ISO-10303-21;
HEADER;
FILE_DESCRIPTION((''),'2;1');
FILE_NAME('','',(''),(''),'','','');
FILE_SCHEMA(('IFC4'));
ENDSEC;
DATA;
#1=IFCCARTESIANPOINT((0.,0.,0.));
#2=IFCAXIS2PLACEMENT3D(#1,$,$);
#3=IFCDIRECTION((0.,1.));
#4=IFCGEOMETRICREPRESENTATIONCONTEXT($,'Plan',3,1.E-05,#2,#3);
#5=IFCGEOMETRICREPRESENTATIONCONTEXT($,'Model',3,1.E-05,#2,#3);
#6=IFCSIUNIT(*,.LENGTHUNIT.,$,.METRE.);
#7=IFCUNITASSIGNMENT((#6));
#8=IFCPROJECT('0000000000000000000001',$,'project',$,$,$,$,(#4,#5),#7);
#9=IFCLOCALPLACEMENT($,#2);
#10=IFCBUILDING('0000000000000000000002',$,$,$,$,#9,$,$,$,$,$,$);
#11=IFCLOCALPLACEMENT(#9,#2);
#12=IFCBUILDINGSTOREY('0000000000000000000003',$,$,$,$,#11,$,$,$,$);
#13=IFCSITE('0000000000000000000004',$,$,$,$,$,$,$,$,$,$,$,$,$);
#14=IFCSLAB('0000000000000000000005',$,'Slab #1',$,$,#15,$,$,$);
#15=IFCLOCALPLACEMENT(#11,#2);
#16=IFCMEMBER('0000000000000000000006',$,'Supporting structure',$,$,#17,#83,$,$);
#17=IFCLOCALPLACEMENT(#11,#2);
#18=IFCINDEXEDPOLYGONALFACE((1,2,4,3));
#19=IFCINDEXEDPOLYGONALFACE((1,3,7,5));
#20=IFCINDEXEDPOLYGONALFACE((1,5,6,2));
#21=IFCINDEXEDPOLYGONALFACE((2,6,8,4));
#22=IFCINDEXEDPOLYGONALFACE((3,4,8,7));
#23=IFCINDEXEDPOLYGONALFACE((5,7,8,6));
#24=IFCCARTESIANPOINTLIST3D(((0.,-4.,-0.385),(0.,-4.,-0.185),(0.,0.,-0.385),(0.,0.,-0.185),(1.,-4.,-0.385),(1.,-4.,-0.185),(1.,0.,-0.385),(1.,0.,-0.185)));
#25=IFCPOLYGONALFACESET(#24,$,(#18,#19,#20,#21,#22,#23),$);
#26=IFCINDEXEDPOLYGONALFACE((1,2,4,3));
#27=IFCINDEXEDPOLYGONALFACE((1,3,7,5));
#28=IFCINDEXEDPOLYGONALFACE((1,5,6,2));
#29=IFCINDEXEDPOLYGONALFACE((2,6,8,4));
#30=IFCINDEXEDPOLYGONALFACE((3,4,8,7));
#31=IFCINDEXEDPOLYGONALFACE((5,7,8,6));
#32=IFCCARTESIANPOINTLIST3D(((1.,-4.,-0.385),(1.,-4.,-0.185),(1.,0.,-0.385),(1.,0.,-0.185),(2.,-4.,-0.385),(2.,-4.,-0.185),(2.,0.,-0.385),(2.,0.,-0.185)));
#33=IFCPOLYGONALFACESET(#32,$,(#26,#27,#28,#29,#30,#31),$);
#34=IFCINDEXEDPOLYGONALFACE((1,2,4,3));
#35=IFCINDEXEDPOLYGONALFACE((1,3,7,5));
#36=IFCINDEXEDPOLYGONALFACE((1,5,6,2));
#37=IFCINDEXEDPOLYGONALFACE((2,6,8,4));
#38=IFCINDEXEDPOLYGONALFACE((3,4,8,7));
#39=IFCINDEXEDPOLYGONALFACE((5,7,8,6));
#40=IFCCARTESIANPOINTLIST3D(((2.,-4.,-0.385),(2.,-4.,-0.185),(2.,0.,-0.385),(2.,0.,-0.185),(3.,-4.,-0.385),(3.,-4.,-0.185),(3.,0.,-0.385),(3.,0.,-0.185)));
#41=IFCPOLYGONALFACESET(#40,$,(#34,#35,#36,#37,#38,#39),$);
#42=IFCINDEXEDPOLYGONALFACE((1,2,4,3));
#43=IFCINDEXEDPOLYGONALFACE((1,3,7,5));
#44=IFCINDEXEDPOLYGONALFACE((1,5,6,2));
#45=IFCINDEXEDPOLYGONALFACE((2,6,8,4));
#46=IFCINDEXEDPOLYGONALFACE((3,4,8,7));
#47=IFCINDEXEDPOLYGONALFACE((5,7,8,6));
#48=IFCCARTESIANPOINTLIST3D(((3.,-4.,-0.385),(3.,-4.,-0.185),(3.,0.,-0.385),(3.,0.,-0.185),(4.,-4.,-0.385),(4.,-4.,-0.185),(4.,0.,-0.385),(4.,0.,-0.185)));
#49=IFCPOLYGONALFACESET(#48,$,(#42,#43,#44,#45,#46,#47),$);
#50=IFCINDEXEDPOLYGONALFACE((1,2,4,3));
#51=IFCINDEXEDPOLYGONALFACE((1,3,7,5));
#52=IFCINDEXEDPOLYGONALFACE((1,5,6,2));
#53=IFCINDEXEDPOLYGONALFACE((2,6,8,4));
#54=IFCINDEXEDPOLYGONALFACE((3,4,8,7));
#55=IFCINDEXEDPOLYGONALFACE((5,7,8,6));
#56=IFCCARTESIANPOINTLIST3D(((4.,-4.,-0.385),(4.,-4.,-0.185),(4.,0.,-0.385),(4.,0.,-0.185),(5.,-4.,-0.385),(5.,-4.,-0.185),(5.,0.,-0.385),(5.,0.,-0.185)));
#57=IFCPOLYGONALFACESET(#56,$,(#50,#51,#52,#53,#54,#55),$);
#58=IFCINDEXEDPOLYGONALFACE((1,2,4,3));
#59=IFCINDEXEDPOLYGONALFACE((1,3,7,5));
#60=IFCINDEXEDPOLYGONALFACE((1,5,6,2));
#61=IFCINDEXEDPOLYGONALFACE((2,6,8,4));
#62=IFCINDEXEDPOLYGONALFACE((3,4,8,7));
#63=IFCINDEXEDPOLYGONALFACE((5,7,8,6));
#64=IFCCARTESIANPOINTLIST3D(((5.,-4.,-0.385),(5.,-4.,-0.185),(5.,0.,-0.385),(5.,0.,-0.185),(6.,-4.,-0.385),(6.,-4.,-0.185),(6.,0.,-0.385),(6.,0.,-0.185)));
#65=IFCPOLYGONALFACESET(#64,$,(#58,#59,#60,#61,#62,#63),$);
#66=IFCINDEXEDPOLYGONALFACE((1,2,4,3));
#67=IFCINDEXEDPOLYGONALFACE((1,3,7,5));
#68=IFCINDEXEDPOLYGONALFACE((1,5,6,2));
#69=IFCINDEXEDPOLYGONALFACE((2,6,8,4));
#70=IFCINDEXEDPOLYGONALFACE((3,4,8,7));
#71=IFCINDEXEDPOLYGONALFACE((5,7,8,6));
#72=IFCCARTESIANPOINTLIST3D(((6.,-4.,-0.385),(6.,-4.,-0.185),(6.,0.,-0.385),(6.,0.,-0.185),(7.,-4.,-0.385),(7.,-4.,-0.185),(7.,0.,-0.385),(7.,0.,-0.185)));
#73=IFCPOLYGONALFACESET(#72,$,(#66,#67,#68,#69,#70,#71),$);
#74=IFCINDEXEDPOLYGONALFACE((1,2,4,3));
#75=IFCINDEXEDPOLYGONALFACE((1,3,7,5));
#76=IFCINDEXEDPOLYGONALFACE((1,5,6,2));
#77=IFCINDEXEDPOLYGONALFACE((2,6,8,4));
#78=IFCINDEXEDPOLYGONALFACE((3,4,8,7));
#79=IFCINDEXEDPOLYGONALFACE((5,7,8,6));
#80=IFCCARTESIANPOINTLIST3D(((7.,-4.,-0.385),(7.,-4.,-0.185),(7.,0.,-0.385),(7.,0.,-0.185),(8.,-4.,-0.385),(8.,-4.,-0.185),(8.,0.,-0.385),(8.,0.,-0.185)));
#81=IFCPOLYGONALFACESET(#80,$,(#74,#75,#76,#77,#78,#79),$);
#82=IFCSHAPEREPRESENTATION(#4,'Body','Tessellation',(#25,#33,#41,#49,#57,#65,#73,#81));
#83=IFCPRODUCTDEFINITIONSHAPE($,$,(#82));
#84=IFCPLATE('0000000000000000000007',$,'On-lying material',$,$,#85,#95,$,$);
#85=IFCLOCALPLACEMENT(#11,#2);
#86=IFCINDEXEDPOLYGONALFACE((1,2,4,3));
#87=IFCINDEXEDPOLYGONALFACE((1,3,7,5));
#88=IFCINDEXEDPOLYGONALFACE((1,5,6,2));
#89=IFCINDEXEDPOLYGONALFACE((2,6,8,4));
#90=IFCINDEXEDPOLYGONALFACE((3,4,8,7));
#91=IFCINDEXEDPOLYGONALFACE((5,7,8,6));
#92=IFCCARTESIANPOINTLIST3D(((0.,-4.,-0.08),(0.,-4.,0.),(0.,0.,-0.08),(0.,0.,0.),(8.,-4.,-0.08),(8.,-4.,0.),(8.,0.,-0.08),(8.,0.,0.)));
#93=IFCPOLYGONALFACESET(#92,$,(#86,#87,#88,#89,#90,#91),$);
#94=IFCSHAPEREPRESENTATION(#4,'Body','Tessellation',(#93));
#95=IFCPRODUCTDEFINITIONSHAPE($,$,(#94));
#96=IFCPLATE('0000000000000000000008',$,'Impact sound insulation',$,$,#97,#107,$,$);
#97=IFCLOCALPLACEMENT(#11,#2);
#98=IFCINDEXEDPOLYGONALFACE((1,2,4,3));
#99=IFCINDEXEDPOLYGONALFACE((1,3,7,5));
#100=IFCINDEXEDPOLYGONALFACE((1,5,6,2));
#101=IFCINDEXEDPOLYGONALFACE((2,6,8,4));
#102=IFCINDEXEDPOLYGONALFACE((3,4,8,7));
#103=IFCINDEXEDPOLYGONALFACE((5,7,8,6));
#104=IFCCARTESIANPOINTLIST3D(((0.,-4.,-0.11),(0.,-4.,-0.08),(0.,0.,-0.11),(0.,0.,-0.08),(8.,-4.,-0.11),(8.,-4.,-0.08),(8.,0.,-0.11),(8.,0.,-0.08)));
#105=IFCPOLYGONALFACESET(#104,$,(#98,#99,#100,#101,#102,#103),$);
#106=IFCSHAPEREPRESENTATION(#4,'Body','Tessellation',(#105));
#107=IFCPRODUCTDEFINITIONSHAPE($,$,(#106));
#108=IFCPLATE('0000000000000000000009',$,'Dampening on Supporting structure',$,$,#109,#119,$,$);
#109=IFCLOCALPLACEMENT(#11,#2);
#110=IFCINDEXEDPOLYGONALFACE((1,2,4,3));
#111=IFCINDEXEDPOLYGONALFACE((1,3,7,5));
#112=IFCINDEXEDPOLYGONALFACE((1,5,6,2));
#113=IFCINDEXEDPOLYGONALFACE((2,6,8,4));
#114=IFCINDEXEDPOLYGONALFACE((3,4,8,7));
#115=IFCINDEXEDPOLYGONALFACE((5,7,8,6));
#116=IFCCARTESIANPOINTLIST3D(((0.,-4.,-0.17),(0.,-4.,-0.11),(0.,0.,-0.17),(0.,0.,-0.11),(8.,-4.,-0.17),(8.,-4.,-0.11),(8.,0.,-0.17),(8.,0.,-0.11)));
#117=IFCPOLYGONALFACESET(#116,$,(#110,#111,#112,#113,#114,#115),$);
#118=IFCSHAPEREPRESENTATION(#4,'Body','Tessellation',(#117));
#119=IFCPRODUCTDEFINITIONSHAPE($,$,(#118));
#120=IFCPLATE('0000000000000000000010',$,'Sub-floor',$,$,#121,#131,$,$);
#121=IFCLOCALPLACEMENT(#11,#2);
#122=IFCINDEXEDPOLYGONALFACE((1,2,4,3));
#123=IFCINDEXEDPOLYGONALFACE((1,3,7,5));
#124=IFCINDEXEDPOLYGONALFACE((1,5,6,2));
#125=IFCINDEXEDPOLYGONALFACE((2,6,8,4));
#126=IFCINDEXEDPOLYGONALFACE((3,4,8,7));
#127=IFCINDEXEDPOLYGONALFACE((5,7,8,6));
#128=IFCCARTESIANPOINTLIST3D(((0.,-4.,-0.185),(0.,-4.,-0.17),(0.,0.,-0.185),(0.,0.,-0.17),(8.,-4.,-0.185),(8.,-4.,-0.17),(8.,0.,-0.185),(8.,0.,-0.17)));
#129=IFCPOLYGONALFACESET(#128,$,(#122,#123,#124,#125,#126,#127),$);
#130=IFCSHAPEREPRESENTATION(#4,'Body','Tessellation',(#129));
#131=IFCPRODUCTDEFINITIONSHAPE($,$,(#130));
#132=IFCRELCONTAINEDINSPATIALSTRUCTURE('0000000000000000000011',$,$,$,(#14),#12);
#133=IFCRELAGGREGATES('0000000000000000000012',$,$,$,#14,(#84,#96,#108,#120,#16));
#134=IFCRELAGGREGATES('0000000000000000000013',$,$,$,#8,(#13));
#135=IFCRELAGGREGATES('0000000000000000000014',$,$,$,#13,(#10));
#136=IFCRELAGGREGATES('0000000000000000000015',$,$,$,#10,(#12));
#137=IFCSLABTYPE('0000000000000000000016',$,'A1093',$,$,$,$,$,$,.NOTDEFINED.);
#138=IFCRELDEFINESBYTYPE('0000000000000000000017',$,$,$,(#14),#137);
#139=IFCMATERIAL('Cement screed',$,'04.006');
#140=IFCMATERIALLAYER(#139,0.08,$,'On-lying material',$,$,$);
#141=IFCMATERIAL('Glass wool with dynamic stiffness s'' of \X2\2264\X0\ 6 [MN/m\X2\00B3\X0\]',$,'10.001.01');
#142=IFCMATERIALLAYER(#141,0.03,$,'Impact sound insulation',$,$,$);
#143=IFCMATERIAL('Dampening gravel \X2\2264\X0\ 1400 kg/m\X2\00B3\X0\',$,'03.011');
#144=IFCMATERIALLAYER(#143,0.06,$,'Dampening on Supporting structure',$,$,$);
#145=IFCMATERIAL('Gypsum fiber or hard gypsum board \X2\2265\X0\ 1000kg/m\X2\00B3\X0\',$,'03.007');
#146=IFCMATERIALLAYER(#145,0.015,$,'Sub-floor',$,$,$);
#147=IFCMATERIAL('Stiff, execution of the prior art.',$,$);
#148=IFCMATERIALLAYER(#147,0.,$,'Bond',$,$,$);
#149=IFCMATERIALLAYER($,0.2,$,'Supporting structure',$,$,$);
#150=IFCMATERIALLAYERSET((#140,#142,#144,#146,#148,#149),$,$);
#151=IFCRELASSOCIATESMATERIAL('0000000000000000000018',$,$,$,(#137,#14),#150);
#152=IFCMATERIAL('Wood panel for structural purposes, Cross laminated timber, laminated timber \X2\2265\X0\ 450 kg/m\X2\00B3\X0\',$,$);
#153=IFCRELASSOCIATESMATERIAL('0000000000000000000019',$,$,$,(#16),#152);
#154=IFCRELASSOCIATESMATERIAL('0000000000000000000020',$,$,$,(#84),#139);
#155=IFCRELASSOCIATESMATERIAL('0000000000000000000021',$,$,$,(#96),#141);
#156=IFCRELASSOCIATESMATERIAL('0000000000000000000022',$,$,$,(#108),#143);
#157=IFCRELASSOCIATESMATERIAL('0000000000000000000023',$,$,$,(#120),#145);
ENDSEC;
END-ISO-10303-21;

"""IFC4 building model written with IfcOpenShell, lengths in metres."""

from ifc_helpers import new_model, si_unit, direction, frame, frame_2d, origin, origin_with_axes, place, context, project, spatial, rectangle, extrude, material, layer, layer_set, type_object, element, aggregate, save


model = new_model("IFC4")

# Units and contexts
plan_context = context("Plan", 3, precision=1e-05, world=origin(), true_north=direction((0.0, 1.0)))
model_context = context("Model", 3, precision=1e-05, world=origin(), true_north=direction((0.0, 1.0)))
ifc_project = project(units=[si_unit("LENGTHUNIT", "METRE")], contexts=[plan_context, model_context])

# Site, building, storey
site = spatial("IfcSite", under=ifc_project)
building_placement = place(None, origin())
building = spatial("IfcBuilding", under=site, at=building_placement)
storey_placement = place(building_placement, origin())
storey = spatial("IfcBuildingStorey", under=building, at=storey_placement)

# Slab, member, plates
ifc_material_1 = material(Name="Cement screed", Category="04.006")
ifc_layer_1 = layer(ifc_material_1, 0.08, Name="On-lying material")
ifc_material_2 = material(Name="Glass wool with dynamic stiffness s' of ≤ 6 [MN/m³]", Category="10.001.01")
ifc_layer_2 = layer(ifc_material_2, 0.03, Name="Impact sound insulation")
ifc_material_3 = material(Name="Dampening gravel ≤ 1400 kg/m³", Category="03.011")
ifc_layer_3 = layer(ifc_material_3, 0.06, Name="Dampening on Supporting structure")
ifc_material_4 = material(Name="Gypsum fiber or hard gypsum board ≥ 1000kg/m³", Category="03.007")
ifc_layer_4 = layer(ifc_material_4, 0.015, Name="Sub-floor")
ifc_material_5 = material(Name="Stiff, execution of the prior art.")
ifc_layer_5 = layer(ifc_material_5, 0.0, Name="Bond")
ifc_layer_6 = layer(None, 0.2, Name="Supporting structure")
ifc_layer_set = layer_set([ifc_layer_1, ifc_layer_2, ifc_layer_3, ifc_layer_4, ifc_layer_5, ifc_layer_6])
slab_type = type_object("IfcSlabType", Name="A1093", PredefinedType="NOTDEFINED", material=ifc_layer_set)
slab_placement = place(None, frame((0.0, 0.0, 0.0), z_axis=(0.0, 0.0, -1.0), x_axis=(1.0, 0.0, 0.0)))
slab = element("IfcSlab", 1, at=slab_placement, inside=storey, type_object=slab_type, material=ifc_layer_set, Name="Slab #1")
ifc_material_6 = material(Name="Wood panel for structural purposes, Cross laminated timber, laminated timber ≥ 450 kg/m³")
member_placement = place(slab_placement, origin())
member = element("IfcMember", 2, at=member_placement, material=ifc_material_6, Name="Supporting structure", context=plan_context, shape_type="SweptSolid", body=[
    extrude(rectangle(XDim=1.0, YDim=0.2, at=frame_2d((0.5, 0.1), x_axis=(1.0, 0.0))), frame((0.0, 4.0, 0.185), z_axis=(0.0, -1.0, 0.0), x_axis=(1.0, 0.0, 0.0)), (0.0, 0.0, 1.0), 4.0),
    extrude(rectangle(XDim=1.0, YDim=0.2, at=frame_2d((0.5, 0.1), x_axis=(1.0, 0.0))), frame((1.0, 4.0, 0.185), z_axis=(0.0, -1.0, 0.0), x_axis=(1.0, 0.0, 0.0)), (0.0, 0.0, 1.0), 4.0),
    extrude(rectangle(XDim=1.0, YDim=0.2, at=frame_2d((0.5, 0.1), x_axis=(1.0, 0.0))), frame((2.0, 4.0, 0.185), z_axis=(0.0, -1.0, 0.0), x_axis=(1.0, 0.0, 0.0)), (0.0, 0.0, 1.0), 4.0),
    extrude(rectangle(XDim=1.0, YDim=0.2, at=frame_2d((0.5, 0.1), x_axis=(1.0, 0.0))), frame((3.0, 4.0, 0.185), z_axis=(0.0, -1.0, 0.0), x_axis=(1.0, 0.0, 0.0)), (0.0, 0.0, 1.0), 4.0),
    extrude(rectangle(XDim=1.0, YDim=0.2, at=frame_2d((0.5, 0.1), x_axis=(1.0, 0.0))), frame((4.0, 4.0, 0.185), z_axis=(0.0, -1.0, 0.0), x_axis=(1.0, 0.0, 0.0)), (0.0, 0.0, 1.0), 4.0),
    extrude(rectangle(XDim=1.0, YDim=0.2, at=frame_2d((0.5, 0.1), x_axis=(1.0, 0.0))), frame((5.0, 4.0, 0.185), z_axis=(0.0, -1.0, 0.0), x_axis=(1.0, 0.0, 0.0)), (0.0, 0.0, 1.0), 4.0),
    extrude(rectangle(XDim=1.0, YDim=0.2, at=frame_2d((0.5, 0.1), x_axis=(1.0, 0.0))), frame((6.0, 4.0, 0.185), z_axis=(0.0, -1.0, 0.0), x_axis=(1.0, 0.0, 0.0)), (0.0, 0.0, 1.0), 4.0),
    extrude(rectangle(XDim=1.0, YDim=0.2, at=frame_2d((0.5, 0.1), x_axis=(1.0, 0.0))), frame((7.0, 4.0, 0.185), z_axis=(0.0, -1.0, 0.0), x_axis=(1.0, 0.0, 0.0)), (0.0, 0.0, 1.0), 4.0),
])
plate_1_placement = place(slab_placement, origin())
plate_1 = element("IfcPlate", 3, at=plate_1_placement, material=ifc_material_1, Name="On-lying material", context=plan_context, shape_type="SweptSolid", body=[
    extrude(rectangle(XDim=8.0, YDim=4.0, at=frame_2d((4.0, 2.0), x_axis=(1.0, 0.0))), origin_with_axes(), (0.0, 0.0, 1.0), 0.08),
])
plate_2_placement = place(slab_placement, origin())
plate_2 = element("IfcPlate", 4, at=plate_2_placement, material=ifc_material_2, Name="Impact sound insulation", context=plan_context, shape_type="SweptSolid", body=[
    extrude(rectangle(XDim=8.0, YDim=4.0, at=frame_2d((4.0, 2.0), x_axis=(1.0, 0.0))), frame((0.0, 0.0, 0.08), z_axis=(0.0, 0.0, 1.0), x_axis=(1.0, 0.0, 0.0)), (0.0, 0.0, 1.0), 0.03),
])
plate_3_placement = place(slab_placement, origin())
plate_3 = element("IfcPlate", 5, at=plate_3_placement, material=ifc_material_3, Name="Dampening on Supporting structure", context=plan_context, shape_type="SweptSolid", body=[
    extrude(rectangle(XDim=8.0, YDim=4.0, at=frame_2d((4.0, 2.0), x_axis=(1.0, 0.0))), frame((0.0, 0.0, 0.11), z_axis=(0.0, 0.0, 1.0), x_axis=(1.0, 0.0, 0.0)), (0.0, 0.0, 1.0), 0.06),
])
plate_4_placement = place(slab_placement, origin())
plate_4 = element("IfcPlate", 6, at=plate_4_placement, material=ifc_material_4, Name="Sub-floor", context=plan_context, shape_type="SweptSolid", body=[
    extrude(rectangle(XDim=8.0, YDim=4.0, at=frame_2d((4.0, 2.0), x_axis=(1.0, 0.0))), frame((0.0, 0.0, 0.17), z_axis=(0.0, 0.0, 1.0), x_axis=(1.0, 0.0, 0.0)), (0.0, 0.0, 1.0), 0.015),
])
aggregate(slab, [plate_1, plate_2, plate_3, plate_4, member])

save(model, "model.ifc")
